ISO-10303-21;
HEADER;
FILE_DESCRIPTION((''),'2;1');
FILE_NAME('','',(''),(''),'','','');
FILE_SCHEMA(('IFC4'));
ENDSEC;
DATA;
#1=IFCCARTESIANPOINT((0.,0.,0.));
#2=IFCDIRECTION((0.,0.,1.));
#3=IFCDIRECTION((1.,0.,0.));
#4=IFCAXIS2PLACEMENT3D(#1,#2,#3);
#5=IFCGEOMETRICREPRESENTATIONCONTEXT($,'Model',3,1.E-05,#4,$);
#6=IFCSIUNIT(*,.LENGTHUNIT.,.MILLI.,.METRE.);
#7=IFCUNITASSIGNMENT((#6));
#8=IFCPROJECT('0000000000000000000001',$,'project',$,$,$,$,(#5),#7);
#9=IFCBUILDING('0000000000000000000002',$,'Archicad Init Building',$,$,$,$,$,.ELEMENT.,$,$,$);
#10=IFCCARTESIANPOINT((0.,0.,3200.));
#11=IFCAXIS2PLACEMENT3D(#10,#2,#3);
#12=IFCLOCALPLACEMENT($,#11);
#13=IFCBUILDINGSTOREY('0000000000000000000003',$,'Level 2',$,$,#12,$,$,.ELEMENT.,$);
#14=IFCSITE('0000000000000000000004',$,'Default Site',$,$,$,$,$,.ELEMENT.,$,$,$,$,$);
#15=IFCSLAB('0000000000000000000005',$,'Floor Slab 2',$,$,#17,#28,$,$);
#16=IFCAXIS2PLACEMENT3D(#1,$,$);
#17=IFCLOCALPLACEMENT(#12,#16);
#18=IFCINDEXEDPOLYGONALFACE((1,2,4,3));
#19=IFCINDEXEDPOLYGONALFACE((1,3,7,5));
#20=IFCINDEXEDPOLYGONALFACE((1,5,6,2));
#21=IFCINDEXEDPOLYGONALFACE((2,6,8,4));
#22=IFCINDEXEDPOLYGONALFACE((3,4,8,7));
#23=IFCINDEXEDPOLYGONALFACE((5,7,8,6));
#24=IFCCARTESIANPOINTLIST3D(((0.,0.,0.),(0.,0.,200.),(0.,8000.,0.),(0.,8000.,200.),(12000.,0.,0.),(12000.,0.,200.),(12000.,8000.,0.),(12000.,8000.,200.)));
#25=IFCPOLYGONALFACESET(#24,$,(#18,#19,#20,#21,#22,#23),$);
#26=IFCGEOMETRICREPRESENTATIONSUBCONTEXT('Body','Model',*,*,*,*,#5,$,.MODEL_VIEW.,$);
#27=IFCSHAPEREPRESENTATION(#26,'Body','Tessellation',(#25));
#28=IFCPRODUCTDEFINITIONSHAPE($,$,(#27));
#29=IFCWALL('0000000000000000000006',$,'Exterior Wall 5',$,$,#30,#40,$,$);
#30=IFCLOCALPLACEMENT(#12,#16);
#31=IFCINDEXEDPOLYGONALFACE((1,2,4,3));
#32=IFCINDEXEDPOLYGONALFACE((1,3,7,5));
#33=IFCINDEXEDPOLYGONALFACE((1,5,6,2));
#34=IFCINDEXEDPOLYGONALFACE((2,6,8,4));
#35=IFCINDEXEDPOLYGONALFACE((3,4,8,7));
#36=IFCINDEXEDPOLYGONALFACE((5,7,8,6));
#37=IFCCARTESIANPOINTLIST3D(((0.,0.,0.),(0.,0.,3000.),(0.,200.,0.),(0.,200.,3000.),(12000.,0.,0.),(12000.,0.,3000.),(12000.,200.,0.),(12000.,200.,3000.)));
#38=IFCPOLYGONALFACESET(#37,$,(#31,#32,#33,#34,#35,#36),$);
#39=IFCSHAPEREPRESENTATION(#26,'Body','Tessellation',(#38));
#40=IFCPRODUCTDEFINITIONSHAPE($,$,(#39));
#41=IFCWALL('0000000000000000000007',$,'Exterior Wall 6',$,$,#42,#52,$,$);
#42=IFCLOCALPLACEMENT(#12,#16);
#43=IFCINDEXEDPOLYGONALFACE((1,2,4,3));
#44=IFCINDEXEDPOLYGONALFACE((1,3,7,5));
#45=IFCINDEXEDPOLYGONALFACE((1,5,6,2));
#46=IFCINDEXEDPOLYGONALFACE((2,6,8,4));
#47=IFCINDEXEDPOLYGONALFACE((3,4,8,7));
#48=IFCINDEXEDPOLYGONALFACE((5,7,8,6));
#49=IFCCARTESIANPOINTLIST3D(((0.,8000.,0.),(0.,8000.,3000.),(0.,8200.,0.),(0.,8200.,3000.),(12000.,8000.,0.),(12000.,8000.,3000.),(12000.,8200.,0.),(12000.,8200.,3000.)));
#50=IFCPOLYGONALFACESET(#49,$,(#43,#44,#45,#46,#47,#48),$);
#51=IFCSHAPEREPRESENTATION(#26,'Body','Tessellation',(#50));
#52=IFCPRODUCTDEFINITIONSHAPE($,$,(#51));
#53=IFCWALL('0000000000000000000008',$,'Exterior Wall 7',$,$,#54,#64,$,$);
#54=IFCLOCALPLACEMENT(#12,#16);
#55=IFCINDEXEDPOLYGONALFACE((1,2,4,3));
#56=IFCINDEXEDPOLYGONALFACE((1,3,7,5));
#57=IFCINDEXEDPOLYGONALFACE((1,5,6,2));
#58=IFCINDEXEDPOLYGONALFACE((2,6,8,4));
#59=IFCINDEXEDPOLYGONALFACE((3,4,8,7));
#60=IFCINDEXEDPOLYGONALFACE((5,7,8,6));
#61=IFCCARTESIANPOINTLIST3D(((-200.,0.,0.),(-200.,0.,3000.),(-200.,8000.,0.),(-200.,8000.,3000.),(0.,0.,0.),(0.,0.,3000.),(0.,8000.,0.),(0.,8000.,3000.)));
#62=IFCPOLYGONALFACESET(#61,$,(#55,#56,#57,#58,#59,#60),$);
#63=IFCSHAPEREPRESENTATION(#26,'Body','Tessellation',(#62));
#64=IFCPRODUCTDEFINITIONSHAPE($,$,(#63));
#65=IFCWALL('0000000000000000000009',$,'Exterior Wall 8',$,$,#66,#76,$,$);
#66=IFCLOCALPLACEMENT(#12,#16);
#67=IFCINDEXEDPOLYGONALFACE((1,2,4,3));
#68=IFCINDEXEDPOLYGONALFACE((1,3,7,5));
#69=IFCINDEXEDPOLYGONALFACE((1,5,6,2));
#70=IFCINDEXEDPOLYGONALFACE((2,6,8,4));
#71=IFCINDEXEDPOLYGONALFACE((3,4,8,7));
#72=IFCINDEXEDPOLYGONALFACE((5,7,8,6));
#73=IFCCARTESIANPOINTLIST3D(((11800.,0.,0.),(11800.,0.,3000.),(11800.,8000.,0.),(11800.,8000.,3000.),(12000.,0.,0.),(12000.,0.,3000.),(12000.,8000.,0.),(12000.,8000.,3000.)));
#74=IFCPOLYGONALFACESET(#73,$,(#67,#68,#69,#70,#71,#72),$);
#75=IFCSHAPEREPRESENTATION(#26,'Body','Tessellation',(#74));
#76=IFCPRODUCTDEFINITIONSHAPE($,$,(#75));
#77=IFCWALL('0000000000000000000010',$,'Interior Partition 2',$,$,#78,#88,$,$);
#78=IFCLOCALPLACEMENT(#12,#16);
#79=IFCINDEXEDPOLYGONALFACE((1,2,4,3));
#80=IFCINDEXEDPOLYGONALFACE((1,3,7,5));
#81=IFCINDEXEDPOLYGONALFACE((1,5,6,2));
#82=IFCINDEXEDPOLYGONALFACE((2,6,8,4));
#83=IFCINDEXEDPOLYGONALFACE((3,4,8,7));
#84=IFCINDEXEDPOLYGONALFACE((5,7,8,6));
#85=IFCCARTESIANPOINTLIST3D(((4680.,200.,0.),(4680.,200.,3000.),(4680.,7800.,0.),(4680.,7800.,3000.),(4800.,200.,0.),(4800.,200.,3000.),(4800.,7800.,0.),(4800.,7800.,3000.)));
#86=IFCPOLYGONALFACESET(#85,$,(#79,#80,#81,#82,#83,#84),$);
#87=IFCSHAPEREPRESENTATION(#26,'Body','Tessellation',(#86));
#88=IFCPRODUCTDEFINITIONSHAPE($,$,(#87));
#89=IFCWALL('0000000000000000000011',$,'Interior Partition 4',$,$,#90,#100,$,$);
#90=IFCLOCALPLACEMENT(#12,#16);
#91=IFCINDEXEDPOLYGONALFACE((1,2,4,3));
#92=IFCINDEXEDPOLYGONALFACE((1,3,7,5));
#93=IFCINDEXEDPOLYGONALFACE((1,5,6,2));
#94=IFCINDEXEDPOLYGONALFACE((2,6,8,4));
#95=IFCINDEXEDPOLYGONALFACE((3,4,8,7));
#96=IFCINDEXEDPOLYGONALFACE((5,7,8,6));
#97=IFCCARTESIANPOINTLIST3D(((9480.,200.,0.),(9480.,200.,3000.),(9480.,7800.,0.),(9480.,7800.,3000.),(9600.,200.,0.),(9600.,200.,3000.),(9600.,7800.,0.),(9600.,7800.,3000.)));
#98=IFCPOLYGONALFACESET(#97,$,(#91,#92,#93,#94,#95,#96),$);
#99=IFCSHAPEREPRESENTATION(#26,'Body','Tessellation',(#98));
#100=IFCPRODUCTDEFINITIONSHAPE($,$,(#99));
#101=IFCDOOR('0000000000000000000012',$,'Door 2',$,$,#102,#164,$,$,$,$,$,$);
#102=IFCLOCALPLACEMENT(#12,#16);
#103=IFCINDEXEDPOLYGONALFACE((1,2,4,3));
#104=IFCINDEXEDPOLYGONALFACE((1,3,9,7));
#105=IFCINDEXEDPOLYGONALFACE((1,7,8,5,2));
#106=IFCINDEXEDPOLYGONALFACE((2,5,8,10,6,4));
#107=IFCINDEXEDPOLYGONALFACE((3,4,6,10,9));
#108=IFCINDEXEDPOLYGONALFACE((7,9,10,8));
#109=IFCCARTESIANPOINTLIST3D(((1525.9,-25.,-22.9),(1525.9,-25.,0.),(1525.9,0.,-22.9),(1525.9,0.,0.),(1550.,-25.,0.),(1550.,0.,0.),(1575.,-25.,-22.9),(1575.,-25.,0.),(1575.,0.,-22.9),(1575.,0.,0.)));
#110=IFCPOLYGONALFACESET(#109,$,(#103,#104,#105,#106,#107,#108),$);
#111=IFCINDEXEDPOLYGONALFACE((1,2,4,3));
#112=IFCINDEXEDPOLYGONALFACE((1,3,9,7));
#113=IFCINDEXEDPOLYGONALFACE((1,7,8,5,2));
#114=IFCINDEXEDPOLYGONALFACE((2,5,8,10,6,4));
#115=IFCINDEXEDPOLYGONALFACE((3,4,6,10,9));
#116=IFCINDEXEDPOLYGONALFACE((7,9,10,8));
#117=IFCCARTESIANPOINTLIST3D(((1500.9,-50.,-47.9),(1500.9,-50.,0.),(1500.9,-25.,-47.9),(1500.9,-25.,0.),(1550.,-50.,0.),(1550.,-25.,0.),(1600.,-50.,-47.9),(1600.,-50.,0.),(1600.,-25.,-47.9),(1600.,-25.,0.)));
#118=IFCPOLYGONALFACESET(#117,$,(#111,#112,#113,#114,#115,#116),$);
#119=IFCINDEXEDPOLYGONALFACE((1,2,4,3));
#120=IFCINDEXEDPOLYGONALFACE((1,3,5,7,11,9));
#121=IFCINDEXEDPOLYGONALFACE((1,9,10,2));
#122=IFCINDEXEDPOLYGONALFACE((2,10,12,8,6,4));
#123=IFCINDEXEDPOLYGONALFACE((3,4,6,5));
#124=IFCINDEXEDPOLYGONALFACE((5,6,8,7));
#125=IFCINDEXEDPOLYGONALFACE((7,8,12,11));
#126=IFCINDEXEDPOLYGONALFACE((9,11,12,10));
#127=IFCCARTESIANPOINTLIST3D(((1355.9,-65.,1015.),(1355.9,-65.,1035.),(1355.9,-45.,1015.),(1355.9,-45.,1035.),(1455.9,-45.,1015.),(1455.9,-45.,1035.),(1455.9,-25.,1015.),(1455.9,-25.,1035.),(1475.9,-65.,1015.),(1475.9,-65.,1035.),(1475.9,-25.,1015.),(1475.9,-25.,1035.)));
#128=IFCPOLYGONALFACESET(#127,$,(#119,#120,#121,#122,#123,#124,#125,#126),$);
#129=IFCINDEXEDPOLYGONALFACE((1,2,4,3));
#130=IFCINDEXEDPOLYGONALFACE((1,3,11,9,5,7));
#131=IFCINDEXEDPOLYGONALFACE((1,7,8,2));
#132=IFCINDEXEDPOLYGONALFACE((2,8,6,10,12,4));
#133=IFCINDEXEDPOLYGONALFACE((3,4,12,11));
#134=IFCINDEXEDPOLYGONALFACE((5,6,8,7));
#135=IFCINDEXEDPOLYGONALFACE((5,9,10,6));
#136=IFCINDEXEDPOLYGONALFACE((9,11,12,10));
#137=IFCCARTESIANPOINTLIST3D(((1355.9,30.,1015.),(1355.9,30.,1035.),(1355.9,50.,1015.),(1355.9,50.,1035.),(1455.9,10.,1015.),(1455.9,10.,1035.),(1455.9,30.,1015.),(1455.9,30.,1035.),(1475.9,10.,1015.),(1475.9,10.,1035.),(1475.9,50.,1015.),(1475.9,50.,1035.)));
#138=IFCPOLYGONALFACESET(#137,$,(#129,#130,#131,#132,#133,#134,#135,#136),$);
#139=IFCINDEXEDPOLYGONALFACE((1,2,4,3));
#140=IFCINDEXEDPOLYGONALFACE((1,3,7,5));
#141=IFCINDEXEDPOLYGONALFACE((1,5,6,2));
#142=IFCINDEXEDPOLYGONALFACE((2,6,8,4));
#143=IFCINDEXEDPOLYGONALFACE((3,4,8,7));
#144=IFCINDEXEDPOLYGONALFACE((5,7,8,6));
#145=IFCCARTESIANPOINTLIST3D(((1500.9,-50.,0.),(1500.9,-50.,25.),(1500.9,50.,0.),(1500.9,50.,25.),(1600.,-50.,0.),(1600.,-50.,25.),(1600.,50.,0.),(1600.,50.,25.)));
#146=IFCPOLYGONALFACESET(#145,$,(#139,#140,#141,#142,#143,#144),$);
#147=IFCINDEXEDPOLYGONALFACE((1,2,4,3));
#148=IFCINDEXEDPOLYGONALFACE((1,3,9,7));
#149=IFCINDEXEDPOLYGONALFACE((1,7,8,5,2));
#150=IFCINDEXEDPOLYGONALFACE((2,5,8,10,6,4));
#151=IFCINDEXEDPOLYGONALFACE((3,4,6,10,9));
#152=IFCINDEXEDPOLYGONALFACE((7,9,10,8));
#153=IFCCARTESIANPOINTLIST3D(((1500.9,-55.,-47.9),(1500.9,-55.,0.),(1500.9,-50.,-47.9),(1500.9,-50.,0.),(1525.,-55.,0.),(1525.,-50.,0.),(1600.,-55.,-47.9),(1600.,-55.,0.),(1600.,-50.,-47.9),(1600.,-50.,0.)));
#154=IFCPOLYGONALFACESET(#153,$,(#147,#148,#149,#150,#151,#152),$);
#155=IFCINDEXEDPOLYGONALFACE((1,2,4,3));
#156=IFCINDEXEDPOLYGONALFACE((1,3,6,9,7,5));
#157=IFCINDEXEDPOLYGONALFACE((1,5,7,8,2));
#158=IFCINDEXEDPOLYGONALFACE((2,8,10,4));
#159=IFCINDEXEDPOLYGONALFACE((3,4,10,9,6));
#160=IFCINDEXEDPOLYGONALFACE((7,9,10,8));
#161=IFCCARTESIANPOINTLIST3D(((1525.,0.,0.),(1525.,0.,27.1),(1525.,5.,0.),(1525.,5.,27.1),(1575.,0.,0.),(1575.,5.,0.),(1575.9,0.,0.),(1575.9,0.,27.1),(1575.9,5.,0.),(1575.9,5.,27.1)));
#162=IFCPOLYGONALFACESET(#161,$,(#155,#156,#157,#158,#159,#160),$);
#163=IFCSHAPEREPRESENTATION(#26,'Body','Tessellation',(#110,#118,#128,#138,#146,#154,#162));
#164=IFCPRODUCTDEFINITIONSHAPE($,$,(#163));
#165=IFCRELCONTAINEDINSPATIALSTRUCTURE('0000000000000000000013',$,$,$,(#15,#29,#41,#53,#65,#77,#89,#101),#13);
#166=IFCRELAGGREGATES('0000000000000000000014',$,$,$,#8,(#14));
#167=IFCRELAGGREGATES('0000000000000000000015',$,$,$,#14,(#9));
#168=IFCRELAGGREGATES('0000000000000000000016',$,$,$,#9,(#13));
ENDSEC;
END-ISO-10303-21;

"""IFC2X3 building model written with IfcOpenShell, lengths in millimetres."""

from ifc_helpers import new_model, si_unit, frame, origin_with_axes, place, context, subcontext, project, spatial, polyline, outline, extrude, element, save


model = new_model("IFC2X3")

# Units and contexts
model_context = context("Model", 3, precision=1e-05, world=origin_with_axes())
body_context = subcontext(model_context, "Body", "Model", "MODEL_VIEW")
ifc_project = project(units=[si_unit("LENGTHUNIT", "METRE", prefix="MILLI")], contexts=[model_context])

# Site, building, storey
site = spatial("IfcSite", under=ifc_project, Name="Default Site", CompositionType="ELEMENT")
building = spatial("IfcBuilding", under=site, Name="Archicad Init Building", CompositionType="ELEMENT")
storey_placement = place(None, frame((0.0, 0.0, 3200.0), z_axis=(0.0, 0.0, 1.0), x_axis=(1.0, 0.0, 0.0)))
storey = spatial("IfcBuildingStorey", under=building, at=storey_placement, Name="Level 2", CompositionType="ELEMENT")

# Slab
slab_placement = place(storey_placement, origin_with_axes())
element("IfcSlab", 1, at=slab_placement, inside=storey, Name="Floor Slab 2", context=body_context, shape_type="SweptSolid", body=[
    extrude(outline(polyline([(0.0, 0.0), (12000.0, 0.0), (12000.0, 8000.0), (0.0, 8000.0), (0.0, 0.0)])), origin_with_axes(), (0.0, 0.0, 1.0), 200.0),
])

# Walls
for number, where, z_axis, x_axis, name in (
    (2, (0.0, 0.0, 0.0), (0.0, 0.0, 1.0), (1.0, 0.0, 0.0), "Exterior Wall 5"),
    (3, (0.0, 8000.0, 0.0), (0.0, 0.0, 1.0), (1.0, 0.0, 0.0), "Exterior Wall 6"),
):
    element("IfcWall", number, at=place(storey_placement, frame(where, z_axis=z_axis, x_axis=x_axis)), inside=storey, Name=name, context=body_context, shape_type="SweptSolid", body=[
        extrude(outline(polyline([(0.0, 0.0), (0.0, 200.0), (12000.0, 200.0), (12000.0, 0.0), (0.0, 0.0)])), origin_with_axes(), (0.0, 0.0, 1.0), 3000.0),
    ])
for number, where, z_axis, x_axis, name in (
    (4, (0.0, 0.0, 0.0), (0.0, 0.0, 1.0), (0.0, 1.0, 0.0), "Exterior Wall 7"),
    (5, (12000.0, 0.0, 0.0), (0.0, 0.0, 1.0), (0.0, 1.0, 0.0), "Exterior Wall 8"),
):
    element("IfcWall", number, at=place(storey_placement, frame(where, z_axis=z_axis, x_axis=x_axis)), inside=storey, Name=name, context=body_context, shape_type="SweptSolid", body=[
        extrude(outline(polyline([(0.0, 0.0), (0.0, 200.0), (8000.0, 200.0), (8000.0, 0.0), (0.0, 0.0)])), origin_with_axes(), (0.0, 0.0, 1.0), 3000.0),
    ])
for number, where, z_axis, x_axis, name in (
    (6, (4800.0, 200.0, 0.0), (0.0, 0.0, 1.0), (0.0, 1.0, 0.0), "Interior Partition 2"),
    (7, (9600.0, 200.0, 0.0), (0.0, 0.0, 1.0), (0.0, 1.0, 0.0), "Interior Partition 4"),
):
    element("IfcWall", number, at=place(storey_placement, frame(where, z_axis=z_axis, x_axis=x_axis)), inside=storey, Name=name, context=body_context, shape_type="SweptSolid", body=[
        extrude(outline(polyline([(0.0, 0.0), (0.0, 120.0), (7600.0, 120.0), (7600.0, 0.0), (0.0, 0.0)])), origin_with_axes(), (0.0, 0.0, 1.0), 3000.0),
    ])

# Door
door_1_placement = place(storey_placement, frame((1550.0, -50.0, 0.0), z_axis=(0.0, 0.0, 1.0), x_axis=(1.0, 0.0, 0.0)))
element("IfcDoor", 8, at=door_1_placement, inside=storey, Name="Door 2", context=body_context, shape_type="SweptSolid", body=[
    extrude(outline(polyline([(0.0, 0.0), (0.0, 2.1), (0.9, 2.1), (0.9, 0.0), (-24.1, 0.0), (-24.1, -22.9), (25.0, -22.9), (25.0, 0.0), (0.0, 0.0)])), frame((0.0, 25.0, 0.0), z_axis=(0.0, -1.0, 0.0), x_axis=(1.0, 0.0, 0.0)), (0.0, 0.0, -1.0), 25.0),
    extrude(outline(polyline([(0.0, 0.0), (0.0, 2.1), (0.9, 2.1), (0.9, 0.0), (-49.1, 0.0), (-49.1, -47.9), (50.0, -47.9), (50.0, 0.0), (0.0, 0.0)])), frame((0.0, 0.0, 0.0), z_axis=(0.0, -1.0, 0.0), x_axis=(1.0, 0.0, 0.0)), (0.0, 0.0, -1.0), 25.0),
    extrude(outline(polyline([(0.0, 0.0), (-49.1, 0.0), (-49.1, 35.0), (0.0, 35.0), (0.0, 0.0)])), frame((25.0, 25.0, 25.0), z_axis=(0.0, 0.0, 1.0), x_axis=(1.0, 0.0, 0.0)), (0.0, 0.0, 1.0), -47.9),
    extrude(outline(polyline([(0.0, 0.0), (0.0, -40.0), (-120.0, -40.0), (-120.0, -20.0), (-20.0, -20.0), (-20.0, 0.0), (0.0, 0.0)])), frame((-74.1, 25.0, 1015.0), z_axis=(0.0, 0.0, 1.0), x_axis=(1.0, 0.0, 0.0)), (0.0, 0.0, 1.0), 20.0),
    extrude(outline(polyline([(0.0, 0.0), (0.0, 40.0), (-120.0, 40.0), (-120.0, 20.0), (-20.0, 20.0), (-20.0, 0.0), (0.0, 0.0)])), frame((-74.1, 60.0, 1015.0), z_axis=(0.0, 0.0, 1.0), x_axis=(1.0, 0.0, 0.0)), (0.0, 0.0, 1.0), 20.0),
    extrude(outline(polyline([(0.0, 0.0), (-99.1, 0.0), (-99.1, 100.0), (0.0, 100.0), (0.0, 0.0)])), frame((50.0, 0.0, 0.0), z_axis=(0.0, 0.0, 1.0), x_axis=(1.0, 0.0, 0.0)), (0.0, 0.0, 1.0), 25.0),
    extrude(outline(polyline([(0.0, 0.0), (0.0, 27.1), (50.9, 27.1), (50.9, 0.0), (-24.1, 0.0), (-24.1, -47.9), (75.0, -47.9), (75.0, 0.0), (0.0, 0.0)])), frame((-25.0, -5.0, 0.0), z_axis=(0.0, -1.0, 0.0), x_axis=(1.0, 0.0, 0.0)), (0.0, 0.0, -1.0), 5.0),
    extrude(outline(polyline([(0.0, 0.0), (0.0, 27.1), (50.9, 27.1), (50.9, 0.0), (0.9, 0.0), (0.9, -22.9), (50.0, -22.9), (50.0, 0.0), (0.0, 0.0)])), frame((-25.0, 50.0, 0.0), z_axis=(0.0, -1.0, 0.0), x_axis=(1.0, 0.0, 0.0)), (0.0, 0.0, -1.0), 5.0),
])

save(model, "model.ifc")
